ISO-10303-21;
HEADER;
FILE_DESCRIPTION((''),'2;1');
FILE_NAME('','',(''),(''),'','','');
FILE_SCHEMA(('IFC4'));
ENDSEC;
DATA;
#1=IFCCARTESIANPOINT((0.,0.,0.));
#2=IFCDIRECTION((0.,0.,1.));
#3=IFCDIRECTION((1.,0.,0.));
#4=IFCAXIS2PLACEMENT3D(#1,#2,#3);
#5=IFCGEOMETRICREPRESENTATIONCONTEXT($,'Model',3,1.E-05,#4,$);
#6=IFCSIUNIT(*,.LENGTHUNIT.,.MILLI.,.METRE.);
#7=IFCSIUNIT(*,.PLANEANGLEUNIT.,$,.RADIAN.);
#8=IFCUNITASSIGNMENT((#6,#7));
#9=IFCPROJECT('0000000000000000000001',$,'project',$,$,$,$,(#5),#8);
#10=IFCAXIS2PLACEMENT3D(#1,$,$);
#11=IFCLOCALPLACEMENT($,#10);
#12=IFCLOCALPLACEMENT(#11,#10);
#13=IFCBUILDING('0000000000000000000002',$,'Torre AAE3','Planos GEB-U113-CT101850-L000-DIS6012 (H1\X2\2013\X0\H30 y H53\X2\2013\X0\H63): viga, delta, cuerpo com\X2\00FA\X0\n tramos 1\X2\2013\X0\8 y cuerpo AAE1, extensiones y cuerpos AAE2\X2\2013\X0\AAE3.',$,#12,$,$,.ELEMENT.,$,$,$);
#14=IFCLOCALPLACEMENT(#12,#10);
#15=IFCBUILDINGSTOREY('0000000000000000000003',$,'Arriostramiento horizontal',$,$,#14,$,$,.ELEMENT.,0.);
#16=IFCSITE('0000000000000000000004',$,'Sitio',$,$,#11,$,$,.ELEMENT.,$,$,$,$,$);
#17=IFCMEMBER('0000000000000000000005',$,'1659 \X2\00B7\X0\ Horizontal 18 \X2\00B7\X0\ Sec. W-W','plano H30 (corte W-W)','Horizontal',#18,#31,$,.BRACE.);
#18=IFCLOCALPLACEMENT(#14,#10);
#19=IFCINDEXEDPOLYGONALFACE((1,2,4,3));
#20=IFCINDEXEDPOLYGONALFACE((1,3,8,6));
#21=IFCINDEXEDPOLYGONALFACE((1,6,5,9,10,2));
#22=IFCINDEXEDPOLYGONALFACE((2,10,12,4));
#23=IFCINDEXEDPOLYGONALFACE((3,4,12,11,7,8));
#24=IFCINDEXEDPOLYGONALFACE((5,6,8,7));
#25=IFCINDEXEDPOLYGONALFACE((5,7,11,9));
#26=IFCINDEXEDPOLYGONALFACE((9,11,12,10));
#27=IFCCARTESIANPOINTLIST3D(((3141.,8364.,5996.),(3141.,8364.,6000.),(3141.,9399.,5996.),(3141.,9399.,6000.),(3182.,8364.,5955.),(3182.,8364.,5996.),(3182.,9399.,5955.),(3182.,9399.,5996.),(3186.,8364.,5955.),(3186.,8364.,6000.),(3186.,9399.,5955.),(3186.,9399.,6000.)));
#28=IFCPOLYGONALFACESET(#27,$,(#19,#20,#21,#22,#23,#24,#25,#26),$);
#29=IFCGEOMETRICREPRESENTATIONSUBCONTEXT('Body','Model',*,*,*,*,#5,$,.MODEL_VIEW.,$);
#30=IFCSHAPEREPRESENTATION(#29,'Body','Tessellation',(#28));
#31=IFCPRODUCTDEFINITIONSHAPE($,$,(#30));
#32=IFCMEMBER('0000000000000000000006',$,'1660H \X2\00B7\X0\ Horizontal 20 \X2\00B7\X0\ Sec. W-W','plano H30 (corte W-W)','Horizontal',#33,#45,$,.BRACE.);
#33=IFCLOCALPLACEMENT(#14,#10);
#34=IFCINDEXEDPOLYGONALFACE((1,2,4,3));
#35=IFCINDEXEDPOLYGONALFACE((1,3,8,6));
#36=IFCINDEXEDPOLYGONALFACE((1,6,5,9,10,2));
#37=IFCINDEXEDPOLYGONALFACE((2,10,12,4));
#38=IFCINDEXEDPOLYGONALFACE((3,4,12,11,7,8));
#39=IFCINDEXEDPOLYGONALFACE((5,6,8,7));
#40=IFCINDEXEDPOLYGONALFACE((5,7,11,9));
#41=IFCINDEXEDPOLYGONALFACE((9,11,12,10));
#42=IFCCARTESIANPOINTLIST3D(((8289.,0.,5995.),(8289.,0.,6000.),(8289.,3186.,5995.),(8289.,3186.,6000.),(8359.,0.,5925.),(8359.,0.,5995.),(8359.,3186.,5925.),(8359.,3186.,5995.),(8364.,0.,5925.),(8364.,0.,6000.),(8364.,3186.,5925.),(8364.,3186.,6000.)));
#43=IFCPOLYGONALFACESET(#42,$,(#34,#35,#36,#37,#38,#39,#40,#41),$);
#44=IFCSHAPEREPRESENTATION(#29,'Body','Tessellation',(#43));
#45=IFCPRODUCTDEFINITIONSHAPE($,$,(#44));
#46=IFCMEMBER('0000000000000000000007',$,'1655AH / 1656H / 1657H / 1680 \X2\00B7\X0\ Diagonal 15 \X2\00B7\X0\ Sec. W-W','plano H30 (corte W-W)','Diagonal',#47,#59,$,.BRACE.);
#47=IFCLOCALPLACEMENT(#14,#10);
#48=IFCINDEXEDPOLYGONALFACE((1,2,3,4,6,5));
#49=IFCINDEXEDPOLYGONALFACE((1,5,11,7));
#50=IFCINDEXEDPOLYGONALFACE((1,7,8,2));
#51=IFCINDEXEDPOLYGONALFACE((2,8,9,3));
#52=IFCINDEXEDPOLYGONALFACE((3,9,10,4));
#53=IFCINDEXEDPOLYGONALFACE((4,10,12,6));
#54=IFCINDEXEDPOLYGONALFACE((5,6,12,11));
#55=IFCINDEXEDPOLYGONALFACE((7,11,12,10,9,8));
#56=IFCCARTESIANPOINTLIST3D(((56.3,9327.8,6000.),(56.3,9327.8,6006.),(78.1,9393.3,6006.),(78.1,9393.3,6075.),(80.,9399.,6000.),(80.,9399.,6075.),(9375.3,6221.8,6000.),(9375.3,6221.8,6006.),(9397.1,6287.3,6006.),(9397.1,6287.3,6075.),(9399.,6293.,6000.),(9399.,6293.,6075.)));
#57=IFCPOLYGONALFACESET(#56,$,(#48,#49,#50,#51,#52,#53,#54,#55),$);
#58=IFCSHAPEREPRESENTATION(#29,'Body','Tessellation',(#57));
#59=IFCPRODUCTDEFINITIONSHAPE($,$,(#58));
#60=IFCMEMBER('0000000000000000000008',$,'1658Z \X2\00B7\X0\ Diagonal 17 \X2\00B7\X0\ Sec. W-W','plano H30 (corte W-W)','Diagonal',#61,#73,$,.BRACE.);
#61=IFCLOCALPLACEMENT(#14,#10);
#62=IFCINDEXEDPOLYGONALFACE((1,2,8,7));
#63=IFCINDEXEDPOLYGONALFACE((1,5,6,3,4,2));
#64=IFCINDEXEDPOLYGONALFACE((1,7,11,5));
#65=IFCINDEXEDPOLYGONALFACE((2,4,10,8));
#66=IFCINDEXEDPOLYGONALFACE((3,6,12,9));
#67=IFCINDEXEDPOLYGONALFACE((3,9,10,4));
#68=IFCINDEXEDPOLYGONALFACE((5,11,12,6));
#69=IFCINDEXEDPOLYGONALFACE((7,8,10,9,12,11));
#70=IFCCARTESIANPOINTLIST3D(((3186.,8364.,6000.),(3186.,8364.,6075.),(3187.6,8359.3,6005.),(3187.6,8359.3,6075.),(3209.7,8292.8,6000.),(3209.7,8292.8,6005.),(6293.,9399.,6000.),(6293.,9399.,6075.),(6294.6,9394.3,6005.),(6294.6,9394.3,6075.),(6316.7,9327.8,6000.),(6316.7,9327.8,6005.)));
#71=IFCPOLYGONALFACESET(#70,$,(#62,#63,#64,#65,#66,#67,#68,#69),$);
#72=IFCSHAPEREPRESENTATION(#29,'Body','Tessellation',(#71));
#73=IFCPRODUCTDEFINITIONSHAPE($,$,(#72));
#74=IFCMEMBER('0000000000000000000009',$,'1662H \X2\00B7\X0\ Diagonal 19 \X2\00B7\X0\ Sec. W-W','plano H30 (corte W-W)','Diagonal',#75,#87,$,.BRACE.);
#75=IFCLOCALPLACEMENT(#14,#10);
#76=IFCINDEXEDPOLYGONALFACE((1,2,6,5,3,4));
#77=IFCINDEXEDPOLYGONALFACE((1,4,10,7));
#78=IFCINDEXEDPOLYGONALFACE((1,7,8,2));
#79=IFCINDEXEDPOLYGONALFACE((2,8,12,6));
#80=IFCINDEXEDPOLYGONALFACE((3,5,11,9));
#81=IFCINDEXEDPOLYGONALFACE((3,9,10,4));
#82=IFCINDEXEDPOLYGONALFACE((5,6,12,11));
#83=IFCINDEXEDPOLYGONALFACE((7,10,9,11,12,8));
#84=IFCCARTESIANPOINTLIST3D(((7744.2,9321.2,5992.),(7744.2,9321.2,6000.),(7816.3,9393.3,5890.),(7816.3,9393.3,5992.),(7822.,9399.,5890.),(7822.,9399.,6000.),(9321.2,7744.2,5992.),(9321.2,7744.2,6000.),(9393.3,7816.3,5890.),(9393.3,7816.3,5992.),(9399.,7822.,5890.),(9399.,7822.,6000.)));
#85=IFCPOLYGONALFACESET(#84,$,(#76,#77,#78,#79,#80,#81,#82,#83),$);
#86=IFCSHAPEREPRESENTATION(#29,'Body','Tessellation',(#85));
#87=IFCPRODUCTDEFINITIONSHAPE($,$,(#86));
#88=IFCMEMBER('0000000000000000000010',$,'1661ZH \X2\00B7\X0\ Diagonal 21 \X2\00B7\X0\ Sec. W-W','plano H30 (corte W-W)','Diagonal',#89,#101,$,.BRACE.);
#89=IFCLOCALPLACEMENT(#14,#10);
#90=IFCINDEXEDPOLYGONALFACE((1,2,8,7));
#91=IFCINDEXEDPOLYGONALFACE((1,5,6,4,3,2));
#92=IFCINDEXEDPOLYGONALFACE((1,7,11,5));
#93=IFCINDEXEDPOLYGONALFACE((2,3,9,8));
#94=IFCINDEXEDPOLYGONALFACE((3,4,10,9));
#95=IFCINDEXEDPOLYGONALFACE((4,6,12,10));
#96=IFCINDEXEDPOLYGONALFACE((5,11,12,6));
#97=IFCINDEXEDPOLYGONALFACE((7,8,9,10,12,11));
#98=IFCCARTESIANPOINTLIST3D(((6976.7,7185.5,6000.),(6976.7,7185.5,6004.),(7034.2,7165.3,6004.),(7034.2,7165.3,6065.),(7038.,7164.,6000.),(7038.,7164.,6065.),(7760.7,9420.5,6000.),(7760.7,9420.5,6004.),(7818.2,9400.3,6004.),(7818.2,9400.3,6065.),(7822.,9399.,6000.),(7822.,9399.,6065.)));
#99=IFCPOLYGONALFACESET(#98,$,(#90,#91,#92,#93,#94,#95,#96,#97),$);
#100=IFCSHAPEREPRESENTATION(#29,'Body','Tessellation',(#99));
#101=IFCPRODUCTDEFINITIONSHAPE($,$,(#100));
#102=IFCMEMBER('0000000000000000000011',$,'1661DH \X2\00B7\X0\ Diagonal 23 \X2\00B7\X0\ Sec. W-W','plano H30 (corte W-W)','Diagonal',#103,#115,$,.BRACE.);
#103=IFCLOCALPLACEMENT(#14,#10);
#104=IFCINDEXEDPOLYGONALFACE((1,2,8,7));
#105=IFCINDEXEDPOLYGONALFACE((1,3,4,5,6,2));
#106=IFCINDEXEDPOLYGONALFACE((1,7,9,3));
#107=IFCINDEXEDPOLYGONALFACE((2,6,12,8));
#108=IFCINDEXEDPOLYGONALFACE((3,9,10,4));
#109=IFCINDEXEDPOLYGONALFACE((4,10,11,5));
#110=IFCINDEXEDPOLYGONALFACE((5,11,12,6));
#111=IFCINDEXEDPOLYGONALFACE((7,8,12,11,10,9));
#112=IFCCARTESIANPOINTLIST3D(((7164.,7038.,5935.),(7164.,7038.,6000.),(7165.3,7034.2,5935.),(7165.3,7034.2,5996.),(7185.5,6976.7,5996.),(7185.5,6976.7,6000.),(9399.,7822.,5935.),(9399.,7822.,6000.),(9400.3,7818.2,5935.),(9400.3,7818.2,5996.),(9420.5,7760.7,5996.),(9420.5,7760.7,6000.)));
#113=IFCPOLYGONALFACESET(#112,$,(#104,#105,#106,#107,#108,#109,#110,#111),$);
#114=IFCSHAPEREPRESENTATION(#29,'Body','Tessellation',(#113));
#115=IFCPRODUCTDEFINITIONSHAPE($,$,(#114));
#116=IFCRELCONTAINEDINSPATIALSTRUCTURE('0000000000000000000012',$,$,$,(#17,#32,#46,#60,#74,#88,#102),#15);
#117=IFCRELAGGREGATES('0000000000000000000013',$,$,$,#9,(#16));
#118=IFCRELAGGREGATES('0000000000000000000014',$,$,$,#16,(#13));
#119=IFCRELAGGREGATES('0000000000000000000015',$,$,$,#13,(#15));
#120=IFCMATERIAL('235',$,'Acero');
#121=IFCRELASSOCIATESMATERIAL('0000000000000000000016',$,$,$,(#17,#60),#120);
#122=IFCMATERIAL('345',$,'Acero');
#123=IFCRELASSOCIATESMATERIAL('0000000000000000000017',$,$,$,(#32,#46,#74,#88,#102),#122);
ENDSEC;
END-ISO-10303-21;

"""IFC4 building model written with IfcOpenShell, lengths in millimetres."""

from ifc_helpers import new_model, si_unit, frame, frame_2d, origin, origin_with_axes, place, context, subcontext, project, spatial, l_section, extrude, material, element, save


model = new_model("IFC4")

# Units and contexts
model_context = context("Model", 3, precision=1e-05, world=origin_with_axes())
body_context = subcontext(model_context, "Body", "Model", "MODEL_VIEW")
ifc_project = project(units=[si_unit("LENGTHUNIT", "METRE", prefix="MILLI"), si_unit("PLANEANGLEUNIT", "RADIAN")], contexts=[model_context])

# Site, building, storey
site_placement = place(None, origin())
site = spatial("IfcSite", under=ifc_project, at=site_placement, Name="Sitio", CompositionType="ELEMENT")
building_placement = place(site_placement, origin())
building = spatial("IfcBuilding", under=site, at=building_placement, Name="Torre AAE3", Description="Planos GEB-U113-CT101850-L000-DIS6012 (H1–H30 y H53–H63): viga, delta, cuerpo común tramos 1–8 y cuerpo AAE1, extensiones y cuerpos AAE2–AAE3.", CompositionType="ELEMENT")
storey_placement = place(building_placement, origin())
storey = spatial("IfcBuildingStorey", under=building, at=storey_placement, Name="Arriostramiento horizontal", CompositionType="ELEMENT", Elevation=0.0)

# Members
ifc_material_1 = material(Name="235", Category="Acero")
ifc_material_2 = material(Name="345", Category="Acero")
for number, where, z_axis, x_axis, name in (
    (1, (3186.0, 9399.0, 6000.0), (0.0, -1.0, 0.0), (-1.0, 0.0, 0.0), "1659 · Horizontal 18 · Sec. W-W"),
):
    element("IfcMember", number, at=place(storey_placement, frame(where, z_axis=z_axis, x_axis=x_axis)), inside=storey, material=ifc_material_1, Name=name, Description="plano H30 (corte W-W)", ObjectType="Horizontal", PredefinedType="BRACE", context=body_context, shape_type="SweptSolid", body=[
        extrude(l_section(Depth=45.0, Width=45.0, Thickness=4.0, at=frame_2d((22.5, 22.5))), None, (0.0, 0.0, 1.0), 1035.0),
    ])
member_1_placement = place(storey_placement, frame((8364.0, 3186.0, 6000.0), z_axis=(0.0, -1.0, 0.0), x_axis=(-1.0, 0.0, 0.0)))
element("IfcMember", 2, at=member_1_placement, inside=storey, material=ifc_material_2, Name="1660H · Horizontal 20 · Sec. W-W", Description="plano H30 (corte W-W)", ObjectType="Horizontal", PredefinedType="BRACE", context=body_context, shape_type="SweptSolid", body=[
    extrude(l_section(Depth=75.0, Width=75.0, Thickness=5.0, at=frame_2d((37.5, 37.5))), None, (0.0, 0.0, 1.0), 3186.0),
])
member_2_placement = place(storey_placement, frame((9399.0, 6293.0, 6000.0), z_axis=(-0.948693, 0.316197, 0.0), x_axis=(-0.316197, -0.948693, 0.0)))
element("IfcMember", 3, at=member_2_placement, inside=storey, material=ifc_material_2, Name="1655AH / 1656H / 1657H / 1680 · Diagonal 15 · Sec. W-W", Description="plano H30 (corte W-W)", ObjectType="Diagonal", PredefinedType="BRACE", context=body_context, shape_type="SweptSolid", body=[
    extrude(l_section(Depth=75.0, Width=75.0, Thickness=6.0, at=frame_2d((37.5, 37.5))), None, (0.0, 0.0, 1.0), 9823.0),
])
member_3_placement = place(storey_placement, frame((6293.0, 9399.0, 6000.0), z_axis=(-0.948744, -0.316045, 0.0), x_axis=(0.316045, -0.948744, 0.0)))
element("IfcMember", 4, at=member_3_placement, inside=storey, material=ifc_material_1, Name="1658Z · Diagonal 17 · Sec. W-W", Description="plano H30 (corte W-W)", ObjectType="Diagonal", PredefinedType="BRACE", context=body_context, shape_type="SweptSolid", body=[
    extrude(l_section(Depth=75.0, Width=75.0, Thickness=5.0, at=frame_2d((37.5, 37.5))), None, (0.0, 0.0, 1.0), 3274.9),
])
member_4_placement = place(storey_placement, frame((7822.0, 9399.0, 6000.0), z_axis=(0.707107, -0.707107, 0.0), x_axis=(-0.707107, -0.707107, 0.0)))
element("IfcMember", 5, at=member_4_placement, inside=storey, material=ifc_material_2, Name="1662H · Diagonal 19 · Sec. W-W", Description="plano H30 (corte W-W)", ObjectType="Diagonal", PredefinedType="BRACE", context=body_context, shape_type="SweptSolid", body=[
    extrude(l_section(Depth=110.0, Width=110.0, Thickness=8.0, at=frame_2d((55.0, 55.0))), None, (0.0, 0.0, 1.0), 2230.2),
])
for number, where, z_axis, x_axis, name in (
    (6, (7038.0, 7164.0, 6000.0), (0.331009, 0.943628, 0.0), (-0.943628, 0.331009, 0.0), "1661ZH · Diagonal 21 · Sec. W-W"),
    (7, (7164.0, 7038.0, 6000.0), (0.943628, 0.331009, 0.0), (0.331009, -0.943628, 0.0), "1661DH · Diagonal 23 · Sec. W-W"),
):
    element("IfcMember", number, at=place(storey_placement, frame(where, z_axis=z_axis, x_axis=x_axis)), inside=storey, material=ifc_material_2, Name=name, Description="plano H30 (corte W-W)", ObjectType="Diagonal", PredefinedType="BRACE", context=body_context, shape_type="SweptSolid", body=[
        extrude(l_section(Depth=65.0, Width=65.0, Thickness=4.0, at=frame_2d((32.5, 32.5))), None, (0.0, 0.0, 1.0), 2368.5),
    ])

save(model, "model.ifc")
